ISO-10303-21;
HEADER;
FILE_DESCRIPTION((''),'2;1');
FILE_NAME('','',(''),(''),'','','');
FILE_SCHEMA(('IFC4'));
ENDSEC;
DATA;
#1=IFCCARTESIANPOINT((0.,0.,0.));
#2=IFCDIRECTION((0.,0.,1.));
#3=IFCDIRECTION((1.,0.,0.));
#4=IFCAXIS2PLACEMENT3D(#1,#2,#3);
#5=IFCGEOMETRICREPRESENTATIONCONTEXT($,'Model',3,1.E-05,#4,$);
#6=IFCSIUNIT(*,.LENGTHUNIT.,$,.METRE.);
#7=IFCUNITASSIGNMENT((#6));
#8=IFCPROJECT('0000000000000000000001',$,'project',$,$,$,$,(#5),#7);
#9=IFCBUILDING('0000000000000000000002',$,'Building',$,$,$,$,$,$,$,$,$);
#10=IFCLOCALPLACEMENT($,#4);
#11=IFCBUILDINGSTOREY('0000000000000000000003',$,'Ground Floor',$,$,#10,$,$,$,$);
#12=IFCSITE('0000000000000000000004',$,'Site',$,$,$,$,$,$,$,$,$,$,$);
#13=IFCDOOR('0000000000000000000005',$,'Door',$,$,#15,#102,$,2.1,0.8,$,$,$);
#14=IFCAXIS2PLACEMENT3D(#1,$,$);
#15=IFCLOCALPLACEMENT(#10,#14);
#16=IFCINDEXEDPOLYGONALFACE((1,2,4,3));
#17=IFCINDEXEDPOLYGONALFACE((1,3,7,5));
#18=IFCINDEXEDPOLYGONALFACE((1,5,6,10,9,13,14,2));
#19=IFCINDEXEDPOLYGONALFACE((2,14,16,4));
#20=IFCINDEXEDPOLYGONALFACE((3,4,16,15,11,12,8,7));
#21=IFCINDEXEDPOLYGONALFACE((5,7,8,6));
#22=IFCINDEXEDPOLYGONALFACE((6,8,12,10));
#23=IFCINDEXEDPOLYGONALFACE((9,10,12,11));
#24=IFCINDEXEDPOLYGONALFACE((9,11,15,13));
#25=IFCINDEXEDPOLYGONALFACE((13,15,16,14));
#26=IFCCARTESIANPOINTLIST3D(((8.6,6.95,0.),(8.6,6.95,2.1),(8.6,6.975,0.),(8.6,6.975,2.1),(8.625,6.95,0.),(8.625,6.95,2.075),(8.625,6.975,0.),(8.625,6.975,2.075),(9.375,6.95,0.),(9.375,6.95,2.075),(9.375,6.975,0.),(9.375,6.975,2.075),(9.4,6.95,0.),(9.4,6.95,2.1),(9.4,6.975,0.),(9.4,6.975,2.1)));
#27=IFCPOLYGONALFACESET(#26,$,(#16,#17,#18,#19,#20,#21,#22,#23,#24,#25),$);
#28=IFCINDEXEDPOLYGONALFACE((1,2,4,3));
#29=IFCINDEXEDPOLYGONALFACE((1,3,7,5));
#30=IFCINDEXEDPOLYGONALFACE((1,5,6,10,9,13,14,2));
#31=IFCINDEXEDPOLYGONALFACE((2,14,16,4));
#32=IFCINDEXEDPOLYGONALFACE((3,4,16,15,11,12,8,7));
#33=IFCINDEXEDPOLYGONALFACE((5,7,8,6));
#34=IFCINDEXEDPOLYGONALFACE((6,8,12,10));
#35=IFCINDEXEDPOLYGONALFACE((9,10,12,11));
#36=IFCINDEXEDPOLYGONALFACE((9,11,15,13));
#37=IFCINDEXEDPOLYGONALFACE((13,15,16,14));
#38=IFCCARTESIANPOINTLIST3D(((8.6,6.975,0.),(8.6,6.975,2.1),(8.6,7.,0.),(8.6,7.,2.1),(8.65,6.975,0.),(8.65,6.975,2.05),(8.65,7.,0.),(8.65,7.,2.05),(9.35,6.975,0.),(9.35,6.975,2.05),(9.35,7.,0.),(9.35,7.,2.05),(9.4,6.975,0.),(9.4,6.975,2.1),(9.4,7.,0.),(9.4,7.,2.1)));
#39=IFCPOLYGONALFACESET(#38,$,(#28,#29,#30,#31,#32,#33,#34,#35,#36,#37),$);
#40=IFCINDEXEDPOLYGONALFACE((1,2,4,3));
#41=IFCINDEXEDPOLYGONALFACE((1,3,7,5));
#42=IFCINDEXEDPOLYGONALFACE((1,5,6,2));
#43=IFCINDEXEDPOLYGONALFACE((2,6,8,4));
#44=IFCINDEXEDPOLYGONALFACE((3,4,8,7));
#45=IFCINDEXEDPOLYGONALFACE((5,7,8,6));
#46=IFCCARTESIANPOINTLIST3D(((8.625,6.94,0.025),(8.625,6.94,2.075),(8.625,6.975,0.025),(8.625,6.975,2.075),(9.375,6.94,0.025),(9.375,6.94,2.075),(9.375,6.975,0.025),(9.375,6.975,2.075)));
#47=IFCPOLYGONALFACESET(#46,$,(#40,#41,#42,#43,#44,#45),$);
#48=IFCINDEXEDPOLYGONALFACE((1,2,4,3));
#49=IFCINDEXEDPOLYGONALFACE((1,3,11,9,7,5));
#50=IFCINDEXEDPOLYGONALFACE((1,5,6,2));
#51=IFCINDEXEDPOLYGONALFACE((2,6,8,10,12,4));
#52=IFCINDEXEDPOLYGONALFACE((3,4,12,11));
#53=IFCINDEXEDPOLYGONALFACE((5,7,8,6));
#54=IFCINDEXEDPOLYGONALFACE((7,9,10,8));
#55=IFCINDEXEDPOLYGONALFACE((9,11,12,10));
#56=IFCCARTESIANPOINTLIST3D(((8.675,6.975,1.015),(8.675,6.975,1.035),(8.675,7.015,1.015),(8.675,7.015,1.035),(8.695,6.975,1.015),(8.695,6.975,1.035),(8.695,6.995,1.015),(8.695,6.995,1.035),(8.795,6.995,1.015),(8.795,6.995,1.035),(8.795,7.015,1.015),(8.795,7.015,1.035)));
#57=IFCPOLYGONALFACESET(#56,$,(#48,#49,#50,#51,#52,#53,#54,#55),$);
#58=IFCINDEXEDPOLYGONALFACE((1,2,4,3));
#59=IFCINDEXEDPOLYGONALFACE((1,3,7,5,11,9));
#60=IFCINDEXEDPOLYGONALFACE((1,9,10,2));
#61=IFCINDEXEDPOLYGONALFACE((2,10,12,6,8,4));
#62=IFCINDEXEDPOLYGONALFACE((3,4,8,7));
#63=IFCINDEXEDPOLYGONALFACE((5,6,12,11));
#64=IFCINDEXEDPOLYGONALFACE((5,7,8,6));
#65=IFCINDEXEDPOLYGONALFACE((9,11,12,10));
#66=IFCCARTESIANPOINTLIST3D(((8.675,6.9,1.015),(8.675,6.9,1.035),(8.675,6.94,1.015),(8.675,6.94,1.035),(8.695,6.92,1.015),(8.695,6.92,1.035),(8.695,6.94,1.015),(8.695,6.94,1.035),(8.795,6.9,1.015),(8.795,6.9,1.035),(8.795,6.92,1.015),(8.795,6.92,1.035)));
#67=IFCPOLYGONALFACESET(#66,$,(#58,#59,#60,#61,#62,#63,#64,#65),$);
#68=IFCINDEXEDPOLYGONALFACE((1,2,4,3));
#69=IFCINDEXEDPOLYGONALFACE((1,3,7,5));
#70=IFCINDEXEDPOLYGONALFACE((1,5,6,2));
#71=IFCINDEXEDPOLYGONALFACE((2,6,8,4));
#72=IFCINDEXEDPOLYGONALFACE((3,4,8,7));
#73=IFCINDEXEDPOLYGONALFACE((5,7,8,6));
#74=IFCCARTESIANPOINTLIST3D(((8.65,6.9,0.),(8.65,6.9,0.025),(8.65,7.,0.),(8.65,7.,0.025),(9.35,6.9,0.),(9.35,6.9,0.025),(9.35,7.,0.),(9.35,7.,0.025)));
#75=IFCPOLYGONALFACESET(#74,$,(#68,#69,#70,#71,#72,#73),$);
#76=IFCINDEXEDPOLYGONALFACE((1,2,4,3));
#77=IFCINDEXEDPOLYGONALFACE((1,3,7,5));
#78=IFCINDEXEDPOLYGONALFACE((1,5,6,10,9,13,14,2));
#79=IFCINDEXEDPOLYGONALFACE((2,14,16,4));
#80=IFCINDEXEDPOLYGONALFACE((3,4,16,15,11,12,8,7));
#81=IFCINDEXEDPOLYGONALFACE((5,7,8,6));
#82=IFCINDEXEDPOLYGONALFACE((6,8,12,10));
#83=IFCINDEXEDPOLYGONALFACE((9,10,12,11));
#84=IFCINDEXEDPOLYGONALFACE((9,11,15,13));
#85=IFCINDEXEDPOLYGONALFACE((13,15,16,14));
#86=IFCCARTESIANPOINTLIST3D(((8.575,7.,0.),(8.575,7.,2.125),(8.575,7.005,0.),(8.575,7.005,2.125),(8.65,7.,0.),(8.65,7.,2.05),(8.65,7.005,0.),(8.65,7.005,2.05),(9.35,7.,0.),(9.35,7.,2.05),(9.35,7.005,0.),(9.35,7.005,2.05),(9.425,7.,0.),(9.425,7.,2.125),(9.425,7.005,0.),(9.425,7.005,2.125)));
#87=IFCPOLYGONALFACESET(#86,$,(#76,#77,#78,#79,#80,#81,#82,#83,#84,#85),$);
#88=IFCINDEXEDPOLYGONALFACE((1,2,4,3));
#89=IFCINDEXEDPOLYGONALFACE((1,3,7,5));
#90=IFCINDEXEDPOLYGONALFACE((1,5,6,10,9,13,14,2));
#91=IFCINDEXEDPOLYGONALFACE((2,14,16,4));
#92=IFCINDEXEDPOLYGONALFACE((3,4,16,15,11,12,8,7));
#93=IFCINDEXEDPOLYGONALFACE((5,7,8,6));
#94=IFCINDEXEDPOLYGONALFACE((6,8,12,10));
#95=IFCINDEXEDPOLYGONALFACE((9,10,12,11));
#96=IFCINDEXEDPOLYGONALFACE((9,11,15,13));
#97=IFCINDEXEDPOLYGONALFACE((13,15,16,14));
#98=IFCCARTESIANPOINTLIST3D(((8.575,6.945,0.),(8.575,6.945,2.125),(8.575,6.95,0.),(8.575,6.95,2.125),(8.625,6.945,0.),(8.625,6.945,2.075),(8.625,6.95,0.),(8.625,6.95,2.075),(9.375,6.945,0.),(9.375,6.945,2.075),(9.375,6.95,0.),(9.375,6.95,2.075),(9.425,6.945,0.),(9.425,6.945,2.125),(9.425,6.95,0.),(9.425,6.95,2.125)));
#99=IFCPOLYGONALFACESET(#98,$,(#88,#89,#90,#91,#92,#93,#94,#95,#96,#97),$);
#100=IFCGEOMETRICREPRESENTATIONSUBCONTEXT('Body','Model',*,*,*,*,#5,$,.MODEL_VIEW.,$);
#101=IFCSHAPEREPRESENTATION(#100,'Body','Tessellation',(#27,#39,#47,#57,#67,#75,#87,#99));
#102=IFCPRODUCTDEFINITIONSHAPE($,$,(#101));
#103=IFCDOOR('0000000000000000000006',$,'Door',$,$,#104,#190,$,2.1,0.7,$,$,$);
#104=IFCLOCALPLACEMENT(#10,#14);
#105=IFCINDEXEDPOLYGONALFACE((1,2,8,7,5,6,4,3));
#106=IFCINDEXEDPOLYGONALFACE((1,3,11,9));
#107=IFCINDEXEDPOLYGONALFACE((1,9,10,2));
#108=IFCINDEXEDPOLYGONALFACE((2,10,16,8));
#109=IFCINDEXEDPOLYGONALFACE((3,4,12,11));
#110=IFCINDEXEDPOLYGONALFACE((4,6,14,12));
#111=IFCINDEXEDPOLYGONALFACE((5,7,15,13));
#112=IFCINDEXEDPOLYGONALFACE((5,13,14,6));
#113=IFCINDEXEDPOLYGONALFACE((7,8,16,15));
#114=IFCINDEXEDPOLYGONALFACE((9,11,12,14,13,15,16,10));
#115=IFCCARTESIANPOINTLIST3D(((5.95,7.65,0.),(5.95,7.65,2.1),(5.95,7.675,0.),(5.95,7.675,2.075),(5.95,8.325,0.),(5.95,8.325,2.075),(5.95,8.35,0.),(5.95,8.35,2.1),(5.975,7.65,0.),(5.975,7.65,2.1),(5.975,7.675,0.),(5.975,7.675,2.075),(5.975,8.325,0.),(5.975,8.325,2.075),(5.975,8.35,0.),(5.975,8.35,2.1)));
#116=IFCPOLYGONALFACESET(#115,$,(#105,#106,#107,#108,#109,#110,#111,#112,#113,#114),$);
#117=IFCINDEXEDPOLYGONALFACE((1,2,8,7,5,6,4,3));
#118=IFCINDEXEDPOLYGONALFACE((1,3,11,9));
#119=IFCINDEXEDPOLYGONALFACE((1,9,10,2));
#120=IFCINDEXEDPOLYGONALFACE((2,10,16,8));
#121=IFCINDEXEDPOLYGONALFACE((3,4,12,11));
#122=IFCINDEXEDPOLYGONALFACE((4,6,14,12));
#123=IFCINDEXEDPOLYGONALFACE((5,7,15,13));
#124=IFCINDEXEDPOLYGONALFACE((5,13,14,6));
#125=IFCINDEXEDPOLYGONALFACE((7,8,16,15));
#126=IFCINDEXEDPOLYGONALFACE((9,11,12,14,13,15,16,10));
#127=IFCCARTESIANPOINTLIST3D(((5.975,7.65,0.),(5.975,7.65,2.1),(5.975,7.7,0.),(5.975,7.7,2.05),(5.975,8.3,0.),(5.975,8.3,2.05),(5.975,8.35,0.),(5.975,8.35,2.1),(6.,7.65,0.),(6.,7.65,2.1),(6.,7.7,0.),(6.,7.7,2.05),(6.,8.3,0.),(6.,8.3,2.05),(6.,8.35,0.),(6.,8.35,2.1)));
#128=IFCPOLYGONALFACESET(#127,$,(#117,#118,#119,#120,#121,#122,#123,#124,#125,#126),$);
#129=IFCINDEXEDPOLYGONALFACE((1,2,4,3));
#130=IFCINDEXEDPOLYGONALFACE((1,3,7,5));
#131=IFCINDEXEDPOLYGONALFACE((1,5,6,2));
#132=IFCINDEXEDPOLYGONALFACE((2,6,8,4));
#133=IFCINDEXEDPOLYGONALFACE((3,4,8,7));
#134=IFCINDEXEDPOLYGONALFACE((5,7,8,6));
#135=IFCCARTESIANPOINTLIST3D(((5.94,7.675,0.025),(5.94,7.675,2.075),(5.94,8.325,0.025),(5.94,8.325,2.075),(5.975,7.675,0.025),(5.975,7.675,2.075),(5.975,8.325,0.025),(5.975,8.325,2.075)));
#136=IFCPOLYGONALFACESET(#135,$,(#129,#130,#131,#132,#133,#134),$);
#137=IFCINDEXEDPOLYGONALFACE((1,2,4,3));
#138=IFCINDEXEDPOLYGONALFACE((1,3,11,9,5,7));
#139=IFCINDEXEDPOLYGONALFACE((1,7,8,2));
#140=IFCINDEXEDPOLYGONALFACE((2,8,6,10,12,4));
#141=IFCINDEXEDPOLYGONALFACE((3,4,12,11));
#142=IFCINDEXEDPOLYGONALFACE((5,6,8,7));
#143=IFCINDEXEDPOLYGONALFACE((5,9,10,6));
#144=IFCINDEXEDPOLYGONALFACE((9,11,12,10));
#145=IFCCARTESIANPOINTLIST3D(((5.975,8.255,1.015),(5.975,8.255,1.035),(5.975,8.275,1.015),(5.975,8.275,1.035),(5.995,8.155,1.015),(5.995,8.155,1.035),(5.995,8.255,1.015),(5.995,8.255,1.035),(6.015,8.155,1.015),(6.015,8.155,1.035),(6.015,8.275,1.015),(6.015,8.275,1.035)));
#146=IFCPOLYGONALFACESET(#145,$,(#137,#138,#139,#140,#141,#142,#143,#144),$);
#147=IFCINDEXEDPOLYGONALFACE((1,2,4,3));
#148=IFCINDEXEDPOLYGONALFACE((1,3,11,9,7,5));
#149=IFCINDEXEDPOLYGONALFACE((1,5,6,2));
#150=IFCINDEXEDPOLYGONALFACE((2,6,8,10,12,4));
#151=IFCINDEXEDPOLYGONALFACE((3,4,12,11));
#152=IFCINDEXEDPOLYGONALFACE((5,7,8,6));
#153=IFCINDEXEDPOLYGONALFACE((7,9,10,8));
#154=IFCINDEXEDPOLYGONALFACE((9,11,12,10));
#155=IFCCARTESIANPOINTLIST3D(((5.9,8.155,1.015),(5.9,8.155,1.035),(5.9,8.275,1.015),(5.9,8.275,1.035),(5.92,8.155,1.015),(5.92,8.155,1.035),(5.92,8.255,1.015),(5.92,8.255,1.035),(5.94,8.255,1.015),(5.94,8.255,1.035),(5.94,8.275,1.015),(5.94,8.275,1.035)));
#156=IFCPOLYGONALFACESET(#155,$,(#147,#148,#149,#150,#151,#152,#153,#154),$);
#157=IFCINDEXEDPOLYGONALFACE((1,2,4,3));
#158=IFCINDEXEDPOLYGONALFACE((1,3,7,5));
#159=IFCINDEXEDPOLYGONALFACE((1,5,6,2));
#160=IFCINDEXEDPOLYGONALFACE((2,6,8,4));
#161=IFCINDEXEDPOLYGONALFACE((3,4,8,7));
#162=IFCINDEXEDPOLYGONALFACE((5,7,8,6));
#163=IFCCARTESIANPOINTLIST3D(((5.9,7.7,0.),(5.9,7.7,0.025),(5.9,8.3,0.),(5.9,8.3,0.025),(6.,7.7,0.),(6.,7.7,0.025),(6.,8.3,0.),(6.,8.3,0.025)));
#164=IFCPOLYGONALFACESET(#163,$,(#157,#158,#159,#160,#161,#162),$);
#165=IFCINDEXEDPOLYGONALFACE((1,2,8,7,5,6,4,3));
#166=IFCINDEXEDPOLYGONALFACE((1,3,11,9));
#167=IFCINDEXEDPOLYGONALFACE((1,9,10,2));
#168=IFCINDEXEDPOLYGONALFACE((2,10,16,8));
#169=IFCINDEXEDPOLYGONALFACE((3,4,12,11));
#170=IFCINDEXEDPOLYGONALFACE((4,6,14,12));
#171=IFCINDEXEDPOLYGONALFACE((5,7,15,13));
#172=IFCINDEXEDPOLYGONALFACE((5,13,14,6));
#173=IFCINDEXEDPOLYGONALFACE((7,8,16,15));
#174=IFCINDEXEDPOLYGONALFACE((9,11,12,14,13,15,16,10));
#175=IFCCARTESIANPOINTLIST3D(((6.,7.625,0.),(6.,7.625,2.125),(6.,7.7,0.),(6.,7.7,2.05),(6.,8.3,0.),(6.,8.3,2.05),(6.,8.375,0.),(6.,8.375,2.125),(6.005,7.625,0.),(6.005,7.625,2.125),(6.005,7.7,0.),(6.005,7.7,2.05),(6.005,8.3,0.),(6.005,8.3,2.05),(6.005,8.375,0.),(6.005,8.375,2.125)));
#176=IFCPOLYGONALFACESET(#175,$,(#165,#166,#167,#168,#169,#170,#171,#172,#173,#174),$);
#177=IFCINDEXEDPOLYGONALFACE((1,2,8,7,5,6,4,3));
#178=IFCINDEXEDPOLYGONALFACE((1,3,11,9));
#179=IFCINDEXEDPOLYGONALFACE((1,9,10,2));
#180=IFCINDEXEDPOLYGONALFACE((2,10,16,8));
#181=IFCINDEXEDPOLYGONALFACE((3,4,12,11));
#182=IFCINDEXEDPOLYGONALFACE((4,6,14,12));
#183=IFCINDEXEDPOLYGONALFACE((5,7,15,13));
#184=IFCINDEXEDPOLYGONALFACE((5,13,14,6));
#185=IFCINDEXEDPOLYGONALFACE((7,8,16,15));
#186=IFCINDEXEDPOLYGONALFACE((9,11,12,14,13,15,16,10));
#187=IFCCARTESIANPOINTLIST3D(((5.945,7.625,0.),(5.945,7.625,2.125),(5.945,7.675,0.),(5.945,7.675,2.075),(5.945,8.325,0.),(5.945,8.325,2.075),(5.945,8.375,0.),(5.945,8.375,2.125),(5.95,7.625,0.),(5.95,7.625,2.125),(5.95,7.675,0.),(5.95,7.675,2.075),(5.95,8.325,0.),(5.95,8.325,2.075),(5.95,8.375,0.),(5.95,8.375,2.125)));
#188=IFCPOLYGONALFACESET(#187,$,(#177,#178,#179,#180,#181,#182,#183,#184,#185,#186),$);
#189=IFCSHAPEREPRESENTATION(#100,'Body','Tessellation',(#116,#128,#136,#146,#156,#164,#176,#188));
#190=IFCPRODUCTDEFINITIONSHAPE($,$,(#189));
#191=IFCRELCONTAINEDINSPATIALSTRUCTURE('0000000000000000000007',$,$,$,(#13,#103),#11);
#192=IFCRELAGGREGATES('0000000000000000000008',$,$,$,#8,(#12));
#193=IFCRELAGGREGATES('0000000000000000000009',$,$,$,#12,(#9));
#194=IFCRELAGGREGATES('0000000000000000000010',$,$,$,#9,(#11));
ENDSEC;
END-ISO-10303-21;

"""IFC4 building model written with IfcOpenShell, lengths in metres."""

from ifc_helpers import new_model, si_unit, frame, origin_with_axes, place, context, subcontext, project, spatial, line, indexed_curve, outline, extrude, element, save


model = new_model("IFC4")

# Units and contexts
model_context = context("Model", 3, precision=1e-05, world=origin_with_axes())
body_context = subcontext(model_context, "Body", "Model", "MODEL_VIEW")
ifc_project = project(units=[si_unit("LENGTHUNIT", "METRE")], contexts=[model_context])

# Site, building, storey
site = spatial("IfcSite", under=ifc_project, Name="Site")
building = spatial("IfcBuilding", under=site, Name="Building")
storey_placement = place(None, origin_with_axes())
storey = spatial("IfcBuildingStorey", under=building, at=storey_placement, Name="Ground Floor")

# Doors
door_1_placement = place(storey_placement, frame((9.4, 7.0, 0.0), z_axis=(0.0, 0.0, 1.0), x_axis=(-1.0, 0.0, 0.0)))
element("IfcDoor", 1, at=door_1_placement, inside=storey, Name="Door", OverallHeight=2.1, OverallWidth=0.8, context=body_context, shape_type="SweptSolid", body=[
    extrude(outline(indexed_curve([(0.0, 0.0), (0.0, 2.1), (0.8, 2.1), (0.8, 0.0), (0.775, 0.0), (0.775, 2.075), (0.025, 2.075), (0.025, 0.0)], segments=[line(1, 2, 3, 4, 5, 6, 7, 8, 1)])), frame((0.0, 0.025, 0.0), z_axis=(0.0, -1.0, 0.0), x_axis=(1.0, 0.0, 0.0)), (0.0, 0.0, -1.0), 0.025),
    extrude(outline(indexed_curve([(0.0, 0.0), (0.0, 2.1), (0.8, 2.1), (0.8, 0.0), (0.75, 0.0), (0.75, 2.05), (0.05, 2.05), (0.05, 0.0)], segments=[line(1, 2, 3, 4, 5, 6, 7, 8, 1)])), frame((0.0, 0.0, 0.0), z_axis=(0.0, -1.0, 0.0), x_axis=(1.0, 0.0, 0.0)), (0.0, 0.0, -1.0), 0.025),
    extrude(outline(indexed_curve([(0.0, 0.0), (0.75, 0.0), (0.75, 0.035), (0.0, 0.035)], segments=[line(1, 2, 3, 4, 1)])), frame((0.025, 0.025, 0.025), z_axis=(0.0, 0.0, 1.0), x_axis=(1.0, 0.0, 0.0)), (0.0, 0.0, 1.0), 2.05),
    extrude(outline(indexed_curve([(0.0, 0.0), (0.0, -0.04), (-0.12, -0.04), (-0.12, -0.02), (-0.02, -0.02), (-0.02, 0.0)], segments=[line(1, 2, 3, 4, 5, 6, 1)])), frame((0.725, 0.025, 1.015), z_axis=(0.0, 0.0, 1.0), x_axis=(1.0, 0.0, 0.0)), (0.0, 0.0, 1.0), 0.02),
    extrude(outline(indexed_curve([(0.0, 0.0), (0.0, 0.04), (-0.12, 0.04), (-0.12, 0.02), (-0.02, 0.02), (-0.02, 0.0)], segments=[line(1, 2, 3, 4, 5, 6, 1)])), frame((0.725, 0.06, 1.015), z_axis=(0.0, 0.0, 1.0), x_axis=(1.0, 0.0, 0.0)), (0.0, 0.0, 1.0), 0.02),
    extrude(outline(indexed_curve([(0.0, 0.0), (0.7, 0.0), (0.7, 0.1), (0.0, 0.1)], segments=[line(1, 2, 3, 4, 1)])), frame((0.05, 0.0, 0.0), z_axis=(0.0, 0.0, 1.0), x_axis=(1.0, 0.0, 0.0)), (0.0, 0.0, 1.0), 0.025),
    extrude(outline(indexed_curve([(0.0, 0.0), (0.0, 2.125), (0.85, 2.125), (0.85, 0.0), (0.775, 0.0), (0.775, 2.05), (0.075, 2.05), (0.075, 0.0)], segments=[line(1, 2, 3, 4, 5, 6, 7, 8, 1)])), frame((-0.025, -0.005, 0.0), z_axis=(0.0, -1.0, 0.0), x_axis=(1.0, 0.0, 0.0)), (0.0, 0.0, -1.0), 0.005),
    extrude(outline(indexed_curve([(0.0, 0.0), (0.0, 2.125), (0.85, 2.125), (0.85, 0.0), (0.8, 0.0), (0.8, 2.075), (0.05, 2.075), (0.05, 0.0)], segments=[line(1, 2, 3, 4, 5, 6, 7, 8, 1)])), frame((-0.025, 0.05, 0.0), z_axis=(0.0, -1.0, 0.0), x_axis=(1.0, 0.0, 0.0)), (0.0, 0.0, -1.0), 0.005),
])
door_2_placement = place(storey_placement, frame((6.0, 7.65, 0.0), z_axis=(0.0, 0.0, 1.0), x_axis=(0.0, 1.0, 0.0)))
element("IfcDoor", 2, at=door_2_placement, inside=storey, Name="Door", OverallHeight=2.1, OverallWidth=0.7, context=body_context, shape_type="SweptSolid", body=[
    extrude(outline(indexed_curve([(0.0, 0.0), (0.0, 2.1), (0.7, 2.1), (0.7, 0.0), (0.675, 0.0), (0.675, 2.075), (0.025, 2.075), (0.025, 0.0)], segments=[line(1, 2, 3, 4, 5, 6, 7, 8, 1)])), frame((0.0, 0.025, 0.0), z_axis=(0.0, -1.0, 0.0), x_axis=(1.0, 0.0, 0.0)), (0.0, 0.0, -1.0), 0.025),
    extrude(outline(indexed_curve([(0.0, 0.0), (0.0, 2.1), (0.7, 2.1), (0.7, 0.0), (0.65, 0.0), (0.65, 2.05), (0.05, 2.05), (0.05, 0.0)], segments=[line(1, 2, 3, 4, 5, 6, 7, 8, 1)])), frame((0.0, 0.0, 0.0), z_axis=(0.0, -1.0, 0.0), x_axis=(1.0, 0.0, 0.0)), (0.0, 0.0, -1.0), 0.025),
    extrude(outline(indexed_curve([(0.0, 0.0), (0.65, 0.0), (0.65, 0.035), (0.0, 0.035)], segments=[line(1, 2, 3, 4, 1)])), frame((0.025, 0.025, 0.025), z_axis=(0.0, 0.0, 1.0), x_axis=(1.0, 0.0, 0.0)), (0.0, 0.0, 1.0), 2.05),
    extrude(outline(indexed_curve([(0.0, 0.0), (0.0, -0.04), (-0.12, -0.04), (-0.12, -0.02), (-0.02, -0.02), (-0.02, 0.0)], segments=[line(1, 2, 3, 4, 5, 6, 1)])), frame((0.625, 0.025, 1.015), z_axis=(0.0, 0.0, 1.0), x_axis=(1.0, 0.0, 0.0)), (0.0, 0.0, 1.0), 0.02),
    extrude(outline(indexed_curve([(0.0, 0.0), (0.0, 0.04), (-0.12, 0.04), (-0.12, 0.02), (-0.02, 0.02), (-0.02, 0.0)], segments=[line(1, 2, 3, 4, 5, 6, 1)])), frame((0.625, 0.06, 1.015), z_axis=(0.0, 0.0, 1.0), x_axis=(1.0, 0.0, 0.0)), (0.0, 0.0, 1.0), 0.02),
    extrude(outline(indexed_curve([(0.0, 0.0), (0.6, 0.0), (0.6, 0.1), (0.0, 0.1)], segments=[line(1, 2, 3, 4, 1)])), frame((0.05, 0.0, 0.0), z_axis=(0.0, 0.0, 1.0), x_axis=(1.0, 0.0, 0.0)), (0.0, 0.0, 1.0), 0.025),
    extrude(outline(indexed_curve([(0.0, 0.0), (0.0, 2.125), (0.75, 2.125), (0.75, 0.0), (0.675, 0.0), (0.675, 2.05), (0.075, 2.05), (0.075, 0.0)], segments=[line(1, 2, 3, 4, 5, 6, 7, 8, 1)])), frame((-0.025, -0.005, 0.0), z_axis=(0.0, -1.0, 0.0), x_axis=(1.0, 0.0, 0.0)), (0.0, 0.0, -1.0), 0.005),
    extrude(outline(indexed_curve([(0.0, 0.0), (0.0, 2.125), (0.75, 2.125), (0.75, 0.0), (0.7, 0.0), (0.7, 2.075), (0.05, 2.075), (0.05, 0.0)], segments=[line(1, 2, 3, 4, 5, 6, 7, 8, 1)])), frame((-0.025, 0.05, 0.0), z_axis=(0.0, -1.0, 0.0), x_axis=(1.0, 0.0, 0.0)), (0.0, 0.0, -1.0), 0.005),
])

save(model, "model.ifc")
